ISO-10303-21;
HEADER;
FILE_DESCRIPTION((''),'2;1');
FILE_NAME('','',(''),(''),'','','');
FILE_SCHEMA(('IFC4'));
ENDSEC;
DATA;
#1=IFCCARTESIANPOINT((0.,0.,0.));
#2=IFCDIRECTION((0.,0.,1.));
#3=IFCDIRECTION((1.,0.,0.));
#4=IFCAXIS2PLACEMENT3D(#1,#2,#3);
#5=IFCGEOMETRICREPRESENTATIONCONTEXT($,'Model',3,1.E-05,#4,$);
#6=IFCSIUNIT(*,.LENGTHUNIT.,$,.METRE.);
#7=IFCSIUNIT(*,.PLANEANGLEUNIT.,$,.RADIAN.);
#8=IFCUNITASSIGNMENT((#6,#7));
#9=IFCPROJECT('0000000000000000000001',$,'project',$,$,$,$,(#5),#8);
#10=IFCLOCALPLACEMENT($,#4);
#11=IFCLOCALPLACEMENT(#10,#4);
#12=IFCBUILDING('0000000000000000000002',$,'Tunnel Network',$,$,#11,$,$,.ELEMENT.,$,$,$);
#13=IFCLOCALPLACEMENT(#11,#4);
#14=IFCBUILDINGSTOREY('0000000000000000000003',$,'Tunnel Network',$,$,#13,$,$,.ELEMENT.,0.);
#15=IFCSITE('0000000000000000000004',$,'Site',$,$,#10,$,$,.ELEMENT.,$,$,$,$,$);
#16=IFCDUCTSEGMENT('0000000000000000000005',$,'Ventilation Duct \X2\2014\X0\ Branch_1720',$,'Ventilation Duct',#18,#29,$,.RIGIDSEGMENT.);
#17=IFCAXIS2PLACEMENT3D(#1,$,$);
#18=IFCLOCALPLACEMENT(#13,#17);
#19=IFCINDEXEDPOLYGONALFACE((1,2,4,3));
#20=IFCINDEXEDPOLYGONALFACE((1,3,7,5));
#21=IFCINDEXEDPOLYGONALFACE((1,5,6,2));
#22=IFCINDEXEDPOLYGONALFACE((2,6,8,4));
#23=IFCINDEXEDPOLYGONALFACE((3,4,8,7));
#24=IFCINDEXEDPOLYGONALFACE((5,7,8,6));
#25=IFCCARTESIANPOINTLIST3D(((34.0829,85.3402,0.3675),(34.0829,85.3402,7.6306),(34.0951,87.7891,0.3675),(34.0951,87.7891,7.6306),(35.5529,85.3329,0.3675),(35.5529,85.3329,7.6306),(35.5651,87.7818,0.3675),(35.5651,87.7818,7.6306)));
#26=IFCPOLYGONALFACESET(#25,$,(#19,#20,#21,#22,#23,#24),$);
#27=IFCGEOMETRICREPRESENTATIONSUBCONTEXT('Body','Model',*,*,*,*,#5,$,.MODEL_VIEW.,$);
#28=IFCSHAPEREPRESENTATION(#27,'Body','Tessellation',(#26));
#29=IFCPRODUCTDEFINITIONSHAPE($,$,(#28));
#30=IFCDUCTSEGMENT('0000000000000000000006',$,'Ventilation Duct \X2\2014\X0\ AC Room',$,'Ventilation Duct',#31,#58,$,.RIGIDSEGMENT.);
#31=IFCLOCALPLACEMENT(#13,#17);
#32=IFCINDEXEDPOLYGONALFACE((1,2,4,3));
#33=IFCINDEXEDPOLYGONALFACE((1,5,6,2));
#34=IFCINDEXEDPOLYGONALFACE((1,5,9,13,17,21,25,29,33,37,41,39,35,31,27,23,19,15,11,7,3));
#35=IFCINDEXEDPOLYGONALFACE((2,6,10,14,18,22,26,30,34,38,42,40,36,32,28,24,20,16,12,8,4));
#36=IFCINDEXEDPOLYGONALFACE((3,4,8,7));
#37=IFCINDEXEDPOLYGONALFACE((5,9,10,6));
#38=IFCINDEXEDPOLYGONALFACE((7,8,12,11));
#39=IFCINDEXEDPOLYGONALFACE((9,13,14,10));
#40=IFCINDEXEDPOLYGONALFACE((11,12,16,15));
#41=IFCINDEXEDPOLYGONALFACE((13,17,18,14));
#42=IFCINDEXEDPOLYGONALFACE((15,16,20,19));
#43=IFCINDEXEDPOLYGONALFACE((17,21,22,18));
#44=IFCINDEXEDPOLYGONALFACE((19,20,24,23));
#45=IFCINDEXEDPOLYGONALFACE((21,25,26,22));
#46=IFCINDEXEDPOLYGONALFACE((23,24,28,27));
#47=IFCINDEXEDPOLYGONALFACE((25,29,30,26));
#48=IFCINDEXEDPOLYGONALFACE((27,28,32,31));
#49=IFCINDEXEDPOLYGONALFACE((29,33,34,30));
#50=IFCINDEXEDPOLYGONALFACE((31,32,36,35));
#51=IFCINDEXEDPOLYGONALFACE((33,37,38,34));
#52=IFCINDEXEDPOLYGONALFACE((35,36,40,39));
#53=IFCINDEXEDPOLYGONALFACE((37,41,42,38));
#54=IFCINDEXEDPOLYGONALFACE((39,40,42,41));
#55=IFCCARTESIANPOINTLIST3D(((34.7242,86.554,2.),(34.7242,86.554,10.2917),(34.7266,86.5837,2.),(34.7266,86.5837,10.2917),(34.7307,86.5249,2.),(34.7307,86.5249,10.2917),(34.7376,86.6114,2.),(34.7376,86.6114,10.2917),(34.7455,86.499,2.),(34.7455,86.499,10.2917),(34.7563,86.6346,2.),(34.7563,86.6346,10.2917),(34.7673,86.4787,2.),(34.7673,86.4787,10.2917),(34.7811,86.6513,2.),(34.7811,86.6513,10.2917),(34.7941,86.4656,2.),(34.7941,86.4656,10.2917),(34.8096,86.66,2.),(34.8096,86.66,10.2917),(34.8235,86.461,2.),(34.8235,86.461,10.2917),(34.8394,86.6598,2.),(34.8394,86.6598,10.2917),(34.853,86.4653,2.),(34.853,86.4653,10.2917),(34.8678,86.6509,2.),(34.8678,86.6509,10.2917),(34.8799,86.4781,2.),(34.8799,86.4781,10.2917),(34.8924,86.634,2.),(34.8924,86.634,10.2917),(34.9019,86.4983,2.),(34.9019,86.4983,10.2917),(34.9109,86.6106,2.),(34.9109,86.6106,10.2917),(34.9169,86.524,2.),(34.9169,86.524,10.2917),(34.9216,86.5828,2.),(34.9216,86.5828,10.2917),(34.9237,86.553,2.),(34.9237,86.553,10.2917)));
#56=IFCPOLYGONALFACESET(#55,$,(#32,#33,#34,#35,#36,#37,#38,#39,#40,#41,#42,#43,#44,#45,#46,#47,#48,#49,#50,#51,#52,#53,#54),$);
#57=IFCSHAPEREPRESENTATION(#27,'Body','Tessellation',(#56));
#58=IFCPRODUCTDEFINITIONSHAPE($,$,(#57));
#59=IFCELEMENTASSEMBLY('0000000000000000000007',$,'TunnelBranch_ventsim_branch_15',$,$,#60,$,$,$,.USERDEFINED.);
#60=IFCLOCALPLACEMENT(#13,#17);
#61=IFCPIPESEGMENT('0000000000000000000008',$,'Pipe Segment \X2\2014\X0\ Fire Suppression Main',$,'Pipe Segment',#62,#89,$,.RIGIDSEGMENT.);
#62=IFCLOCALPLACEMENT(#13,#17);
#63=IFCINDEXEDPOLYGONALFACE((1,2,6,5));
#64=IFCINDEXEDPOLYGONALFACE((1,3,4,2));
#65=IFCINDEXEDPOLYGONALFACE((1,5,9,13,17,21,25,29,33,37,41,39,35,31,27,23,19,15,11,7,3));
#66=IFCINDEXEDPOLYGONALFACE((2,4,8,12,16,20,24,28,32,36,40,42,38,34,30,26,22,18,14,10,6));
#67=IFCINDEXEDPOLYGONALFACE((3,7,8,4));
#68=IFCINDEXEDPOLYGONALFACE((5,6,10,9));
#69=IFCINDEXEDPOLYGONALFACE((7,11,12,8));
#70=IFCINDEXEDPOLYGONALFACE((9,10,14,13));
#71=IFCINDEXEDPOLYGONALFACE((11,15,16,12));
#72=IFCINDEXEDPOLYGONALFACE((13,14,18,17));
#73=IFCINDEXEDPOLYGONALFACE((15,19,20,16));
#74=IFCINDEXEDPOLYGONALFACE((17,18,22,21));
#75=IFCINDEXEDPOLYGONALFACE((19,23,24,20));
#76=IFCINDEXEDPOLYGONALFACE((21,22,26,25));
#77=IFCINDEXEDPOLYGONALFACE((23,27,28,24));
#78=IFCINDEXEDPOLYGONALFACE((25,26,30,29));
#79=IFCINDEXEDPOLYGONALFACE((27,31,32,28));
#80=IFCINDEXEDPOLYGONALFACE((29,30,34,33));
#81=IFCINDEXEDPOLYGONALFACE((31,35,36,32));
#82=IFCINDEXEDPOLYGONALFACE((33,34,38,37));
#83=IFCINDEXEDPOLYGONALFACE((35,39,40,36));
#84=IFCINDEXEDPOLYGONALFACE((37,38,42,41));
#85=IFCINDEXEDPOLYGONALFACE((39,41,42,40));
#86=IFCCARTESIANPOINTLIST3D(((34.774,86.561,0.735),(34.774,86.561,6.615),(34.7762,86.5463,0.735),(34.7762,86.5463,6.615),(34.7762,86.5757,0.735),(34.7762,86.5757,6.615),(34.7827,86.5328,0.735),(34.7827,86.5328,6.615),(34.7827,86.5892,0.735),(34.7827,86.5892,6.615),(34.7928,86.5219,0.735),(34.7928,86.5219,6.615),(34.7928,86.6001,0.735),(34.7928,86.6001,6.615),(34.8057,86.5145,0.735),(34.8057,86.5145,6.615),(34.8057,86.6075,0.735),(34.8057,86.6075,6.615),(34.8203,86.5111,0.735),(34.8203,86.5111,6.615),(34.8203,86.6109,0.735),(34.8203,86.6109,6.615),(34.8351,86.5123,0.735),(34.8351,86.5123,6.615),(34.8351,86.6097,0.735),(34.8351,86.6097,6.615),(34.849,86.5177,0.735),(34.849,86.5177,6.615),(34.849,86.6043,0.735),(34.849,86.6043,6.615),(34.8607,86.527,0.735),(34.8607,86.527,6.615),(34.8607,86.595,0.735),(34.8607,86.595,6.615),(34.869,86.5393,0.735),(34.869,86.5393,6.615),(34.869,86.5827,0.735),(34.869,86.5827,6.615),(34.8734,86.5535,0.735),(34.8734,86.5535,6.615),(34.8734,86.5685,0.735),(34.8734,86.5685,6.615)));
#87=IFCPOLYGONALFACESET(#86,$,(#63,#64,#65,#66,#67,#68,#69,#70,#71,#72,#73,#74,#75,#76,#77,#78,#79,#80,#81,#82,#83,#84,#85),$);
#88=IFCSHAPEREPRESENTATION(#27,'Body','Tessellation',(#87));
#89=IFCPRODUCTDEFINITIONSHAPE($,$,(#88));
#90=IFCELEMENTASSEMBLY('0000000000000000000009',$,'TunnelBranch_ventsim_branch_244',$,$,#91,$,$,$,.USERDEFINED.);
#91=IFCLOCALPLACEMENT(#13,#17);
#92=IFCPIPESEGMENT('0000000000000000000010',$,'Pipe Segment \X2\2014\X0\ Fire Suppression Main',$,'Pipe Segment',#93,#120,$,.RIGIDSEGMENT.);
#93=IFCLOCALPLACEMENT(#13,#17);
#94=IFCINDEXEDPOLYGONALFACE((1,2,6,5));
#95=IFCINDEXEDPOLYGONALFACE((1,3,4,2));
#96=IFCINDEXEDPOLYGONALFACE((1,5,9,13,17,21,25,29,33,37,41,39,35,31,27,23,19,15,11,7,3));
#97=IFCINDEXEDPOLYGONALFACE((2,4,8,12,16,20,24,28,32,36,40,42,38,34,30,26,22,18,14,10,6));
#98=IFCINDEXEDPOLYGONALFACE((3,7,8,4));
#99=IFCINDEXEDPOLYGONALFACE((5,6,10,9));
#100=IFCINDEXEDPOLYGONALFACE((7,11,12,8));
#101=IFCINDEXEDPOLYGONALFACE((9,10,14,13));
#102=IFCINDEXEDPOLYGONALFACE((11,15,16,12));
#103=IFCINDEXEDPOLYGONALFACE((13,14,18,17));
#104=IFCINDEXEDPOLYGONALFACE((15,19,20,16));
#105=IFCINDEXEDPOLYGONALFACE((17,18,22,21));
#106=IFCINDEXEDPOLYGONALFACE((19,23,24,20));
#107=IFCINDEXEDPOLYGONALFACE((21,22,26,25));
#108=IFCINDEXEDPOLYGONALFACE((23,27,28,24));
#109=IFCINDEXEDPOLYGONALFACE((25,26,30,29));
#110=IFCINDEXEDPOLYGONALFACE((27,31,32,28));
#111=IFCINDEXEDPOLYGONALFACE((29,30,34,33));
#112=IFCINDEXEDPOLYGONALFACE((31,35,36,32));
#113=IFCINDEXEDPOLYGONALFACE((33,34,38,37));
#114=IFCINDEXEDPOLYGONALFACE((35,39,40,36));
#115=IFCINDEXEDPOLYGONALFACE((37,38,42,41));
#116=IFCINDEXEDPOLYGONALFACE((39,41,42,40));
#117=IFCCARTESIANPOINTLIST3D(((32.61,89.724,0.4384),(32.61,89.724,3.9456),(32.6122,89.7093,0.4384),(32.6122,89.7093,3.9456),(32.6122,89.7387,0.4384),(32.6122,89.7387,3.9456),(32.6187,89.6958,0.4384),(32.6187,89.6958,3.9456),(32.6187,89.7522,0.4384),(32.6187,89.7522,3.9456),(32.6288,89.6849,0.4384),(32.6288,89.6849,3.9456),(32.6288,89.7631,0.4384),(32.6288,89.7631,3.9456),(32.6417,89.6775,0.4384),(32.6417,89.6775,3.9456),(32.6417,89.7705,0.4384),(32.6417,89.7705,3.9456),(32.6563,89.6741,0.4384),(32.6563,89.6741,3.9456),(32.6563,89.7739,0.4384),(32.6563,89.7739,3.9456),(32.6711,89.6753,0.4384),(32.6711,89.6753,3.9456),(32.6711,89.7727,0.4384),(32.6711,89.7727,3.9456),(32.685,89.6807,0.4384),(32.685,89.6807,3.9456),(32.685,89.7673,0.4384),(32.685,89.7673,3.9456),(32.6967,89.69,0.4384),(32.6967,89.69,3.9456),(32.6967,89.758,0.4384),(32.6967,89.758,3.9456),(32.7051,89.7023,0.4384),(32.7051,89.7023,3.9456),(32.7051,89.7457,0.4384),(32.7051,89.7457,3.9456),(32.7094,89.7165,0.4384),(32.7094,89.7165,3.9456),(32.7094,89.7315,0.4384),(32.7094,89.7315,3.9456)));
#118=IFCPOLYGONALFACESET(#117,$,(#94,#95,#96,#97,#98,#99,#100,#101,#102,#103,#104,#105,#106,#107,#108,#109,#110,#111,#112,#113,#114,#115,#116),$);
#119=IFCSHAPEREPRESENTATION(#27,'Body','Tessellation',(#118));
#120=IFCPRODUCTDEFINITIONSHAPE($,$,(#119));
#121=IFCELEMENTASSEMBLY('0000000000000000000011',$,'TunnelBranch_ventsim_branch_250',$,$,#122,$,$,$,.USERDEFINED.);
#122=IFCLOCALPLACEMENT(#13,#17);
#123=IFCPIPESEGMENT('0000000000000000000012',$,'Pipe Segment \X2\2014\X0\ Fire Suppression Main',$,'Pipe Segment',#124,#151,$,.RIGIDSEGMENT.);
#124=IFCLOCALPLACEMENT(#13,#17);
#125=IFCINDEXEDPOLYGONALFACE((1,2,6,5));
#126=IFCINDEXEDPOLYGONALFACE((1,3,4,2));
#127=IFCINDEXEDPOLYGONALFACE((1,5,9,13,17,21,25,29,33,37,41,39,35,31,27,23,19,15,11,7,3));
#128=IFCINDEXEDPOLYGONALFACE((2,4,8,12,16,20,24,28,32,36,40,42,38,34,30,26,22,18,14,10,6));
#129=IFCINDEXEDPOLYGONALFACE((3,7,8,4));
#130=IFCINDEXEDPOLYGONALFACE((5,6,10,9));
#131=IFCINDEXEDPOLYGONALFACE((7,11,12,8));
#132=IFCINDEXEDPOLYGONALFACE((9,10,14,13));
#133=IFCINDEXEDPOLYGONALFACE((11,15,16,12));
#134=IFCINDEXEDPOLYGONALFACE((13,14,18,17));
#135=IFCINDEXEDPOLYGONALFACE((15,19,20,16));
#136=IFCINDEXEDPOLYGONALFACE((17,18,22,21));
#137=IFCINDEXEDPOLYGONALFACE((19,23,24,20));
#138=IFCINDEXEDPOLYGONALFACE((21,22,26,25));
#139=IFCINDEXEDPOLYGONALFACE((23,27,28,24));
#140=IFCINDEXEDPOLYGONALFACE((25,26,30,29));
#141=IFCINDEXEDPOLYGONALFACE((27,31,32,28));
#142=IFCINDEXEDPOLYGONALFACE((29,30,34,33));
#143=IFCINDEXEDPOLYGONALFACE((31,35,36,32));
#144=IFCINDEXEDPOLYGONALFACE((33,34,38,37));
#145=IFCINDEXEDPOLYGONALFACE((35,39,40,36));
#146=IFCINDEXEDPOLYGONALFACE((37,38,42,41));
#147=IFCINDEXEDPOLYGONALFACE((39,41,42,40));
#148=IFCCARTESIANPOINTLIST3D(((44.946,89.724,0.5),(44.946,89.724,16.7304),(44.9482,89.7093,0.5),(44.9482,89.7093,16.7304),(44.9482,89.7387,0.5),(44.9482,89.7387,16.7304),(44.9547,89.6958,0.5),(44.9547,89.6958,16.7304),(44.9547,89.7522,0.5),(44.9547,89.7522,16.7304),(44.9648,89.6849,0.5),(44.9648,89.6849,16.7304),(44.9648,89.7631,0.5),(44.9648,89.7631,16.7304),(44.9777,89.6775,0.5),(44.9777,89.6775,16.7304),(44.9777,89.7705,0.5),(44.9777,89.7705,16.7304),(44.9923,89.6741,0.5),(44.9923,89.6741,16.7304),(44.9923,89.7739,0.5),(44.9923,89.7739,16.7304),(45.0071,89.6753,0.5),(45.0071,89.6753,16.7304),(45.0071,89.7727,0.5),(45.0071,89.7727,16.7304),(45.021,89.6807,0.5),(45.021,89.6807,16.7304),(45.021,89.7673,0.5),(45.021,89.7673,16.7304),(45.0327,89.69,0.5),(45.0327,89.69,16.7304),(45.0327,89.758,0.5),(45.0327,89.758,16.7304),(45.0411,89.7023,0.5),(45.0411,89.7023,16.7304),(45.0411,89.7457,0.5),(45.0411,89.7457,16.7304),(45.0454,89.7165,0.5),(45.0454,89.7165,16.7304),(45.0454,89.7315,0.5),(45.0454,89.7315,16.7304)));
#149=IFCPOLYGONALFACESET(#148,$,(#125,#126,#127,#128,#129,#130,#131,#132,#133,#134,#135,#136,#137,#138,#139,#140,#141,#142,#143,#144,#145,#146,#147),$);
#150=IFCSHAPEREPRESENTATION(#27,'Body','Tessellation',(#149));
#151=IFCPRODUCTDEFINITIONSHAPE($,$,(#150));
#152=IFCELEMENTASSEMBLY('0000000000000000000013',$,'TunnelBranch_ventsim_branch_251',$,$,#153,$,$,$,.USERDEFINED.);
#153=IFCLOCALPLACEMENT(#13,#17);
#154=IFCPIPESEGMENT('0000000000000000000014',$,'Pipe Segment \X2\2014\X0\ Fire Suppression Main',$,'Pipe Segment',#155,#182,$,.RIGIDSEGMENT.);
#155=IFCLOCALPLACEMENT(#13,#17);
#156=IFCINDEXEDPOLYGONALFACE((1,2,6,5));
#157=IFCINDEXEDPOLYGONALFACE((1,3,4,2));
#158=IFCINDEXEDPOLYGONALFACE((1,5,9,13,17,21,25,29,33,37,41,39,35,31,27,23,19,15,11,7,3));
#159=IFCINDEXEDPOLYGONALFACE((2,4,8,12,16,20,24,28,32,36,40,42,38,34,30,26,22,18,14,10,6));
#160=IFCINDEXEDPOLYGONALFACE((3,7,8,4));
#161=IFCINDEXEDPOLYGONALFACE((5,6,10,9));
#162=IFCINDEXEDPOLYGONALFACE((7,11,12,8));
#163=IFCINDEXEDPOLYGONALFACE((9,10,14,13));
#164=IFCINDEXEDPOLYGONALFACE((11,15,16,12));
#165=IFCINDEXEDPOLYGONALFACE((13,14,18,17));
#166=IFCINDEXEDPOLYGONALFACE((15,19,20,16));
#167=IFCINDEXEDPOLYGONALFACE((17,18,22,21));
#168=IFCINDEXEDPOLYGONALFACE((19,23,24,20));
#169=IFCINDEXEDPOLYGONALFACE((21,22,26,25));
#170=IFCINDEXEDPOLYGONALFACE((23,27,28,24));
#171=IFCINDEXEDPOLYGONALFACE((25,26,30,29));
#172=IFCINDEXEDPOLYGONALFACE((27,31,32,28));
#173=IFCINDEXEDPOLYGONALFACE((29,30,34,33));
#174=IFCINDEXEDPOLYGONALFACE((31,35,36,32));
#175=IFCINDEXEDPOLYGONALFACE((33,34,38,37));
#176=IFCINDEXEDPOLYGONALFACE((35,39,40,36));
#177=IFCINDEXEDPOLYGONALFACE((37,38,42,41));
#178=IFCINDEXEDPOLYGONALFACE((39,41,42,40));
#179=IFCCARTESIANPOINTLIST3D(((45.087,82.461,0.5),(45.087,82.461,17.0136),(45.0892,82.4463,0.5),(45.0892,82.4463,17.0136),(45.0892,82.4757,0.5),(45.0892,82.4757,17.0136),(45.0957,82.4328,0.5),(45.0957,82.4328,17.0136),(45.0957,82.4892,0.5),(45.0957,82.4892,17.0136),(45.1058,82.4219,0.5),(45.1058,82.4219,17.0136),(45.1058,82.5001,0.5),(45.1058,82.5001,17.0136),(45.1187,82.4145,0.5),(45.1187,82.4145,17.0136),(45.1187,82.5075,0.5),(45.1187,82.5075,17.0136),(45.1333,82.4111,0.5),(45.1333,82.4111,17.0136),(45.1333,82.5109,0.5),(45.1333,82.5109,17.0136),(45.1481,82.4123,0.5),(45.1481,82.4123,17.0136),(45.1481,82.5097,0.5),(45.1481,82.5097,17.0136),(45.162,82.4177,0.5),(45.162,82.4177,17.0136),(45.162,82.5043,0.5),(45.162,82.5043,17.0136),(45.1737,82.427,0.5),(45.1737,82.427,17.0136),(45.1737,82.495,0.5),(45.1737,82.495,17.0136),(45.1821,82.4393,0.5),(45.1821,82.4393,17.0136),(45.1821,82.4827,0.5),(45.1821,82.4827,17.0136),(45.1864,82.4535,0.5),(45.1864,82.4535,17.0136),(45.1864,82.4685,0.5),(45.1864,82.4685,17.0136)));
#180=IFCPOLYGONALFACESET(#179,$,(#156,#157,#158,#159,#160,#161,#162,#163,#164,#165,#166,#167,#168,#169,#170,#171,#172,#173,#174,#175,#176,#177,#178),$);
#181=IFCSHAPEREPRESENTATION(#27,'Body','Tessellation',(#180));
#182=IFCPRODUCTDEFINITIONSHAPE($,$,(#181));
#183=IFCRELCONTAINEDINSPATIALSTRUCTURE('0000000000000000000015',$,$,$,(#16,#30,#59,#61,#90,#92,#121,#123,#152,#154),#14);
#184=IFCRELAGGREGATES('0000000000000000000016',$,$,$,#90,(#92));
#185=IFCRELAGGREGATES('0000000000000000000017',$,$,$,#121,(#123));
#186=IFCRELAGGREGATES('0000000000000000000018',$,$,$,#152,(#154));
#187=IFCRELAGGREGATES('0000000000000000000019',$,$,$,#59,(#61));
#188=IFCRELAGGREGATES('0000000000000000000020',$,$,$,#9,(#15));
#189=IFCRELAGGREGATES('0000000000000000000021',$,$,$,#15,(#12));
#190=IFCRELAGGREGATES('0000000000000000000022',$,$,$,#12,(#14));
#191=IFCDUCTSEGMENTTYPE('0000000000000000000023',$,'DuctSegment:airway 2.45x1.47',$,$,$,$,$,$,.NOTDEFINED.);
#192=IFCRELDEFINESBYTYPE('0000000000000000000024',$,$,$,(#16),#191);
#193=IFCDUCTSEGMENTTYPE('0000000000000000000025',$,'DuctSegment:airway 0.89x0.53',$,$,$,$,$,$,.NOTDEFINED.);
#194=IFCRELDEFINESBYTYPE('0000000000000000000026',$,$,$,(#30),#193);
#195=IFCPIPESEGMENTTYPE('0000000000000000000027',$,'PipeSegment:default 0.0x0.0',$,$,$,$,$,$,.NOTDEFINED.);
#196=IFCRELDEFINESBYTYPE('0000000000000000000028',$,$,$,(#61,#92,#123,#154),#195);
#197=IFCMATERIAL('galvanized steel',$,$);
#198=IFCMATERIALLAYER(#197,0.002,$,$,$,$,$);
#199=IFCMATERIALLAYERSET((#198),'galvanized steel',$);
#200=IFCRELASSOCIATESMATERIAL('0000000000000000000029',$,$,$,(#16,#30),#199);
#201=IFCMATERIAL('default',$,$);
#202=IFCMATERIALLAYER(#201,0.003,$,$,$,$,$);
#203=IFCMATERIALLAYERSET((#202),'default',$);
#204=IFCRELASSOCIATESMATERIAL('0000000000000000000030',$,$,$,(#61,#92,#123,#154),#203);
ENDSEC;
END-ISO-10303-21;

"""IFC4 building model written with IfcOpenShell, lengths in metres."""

from ifc_helpers import new_model, entity, si_unit, frame, origin_with_axes, origin_2d_with_axis, place, context, subcontext, project, spatial, rectangle, circle, extrude, material, layer, layer_set, layer_usage, type_object, element, aggregate, save


model = new_model("IFC4")

# Units and contexts
model_context = context("Model", 3, precision=1e-05, world=origin_with_axes())
body_context = subcontext(model_context, "Body", "Model", "MODEL_VIEW")
ifc_project = project(units=[si_unit("LENGTHUNIT", "METRE"), si_unit("PLANEANGLEUNIT", "RADIAN")], contexts=[model_context])

# Site, building, storey
site_placement = place(None, origin_with_axes())
site = spatial("IfcSite", under=ifc_project, at=site_placement, Name="Site", CompositionType="ELEMENT")
building_placement = place(site_placement, origin_with_axes())
building = spatial("IfcBuilding", under=site, at=building_placement, Name="Tunnel Network", CompositionType="ELEMENT")
storey_placement = place(building_placement, origin_with_axes())
storey = spatial("IfcBuildingStorey", under=building, at=storey_placement, Name="Tunnel Network", CompositionType="ELEMENT", Elevation=0.0)

# Duct segments
ifc_material_1 = material(Name="galvanized steel")
ifc_layer_1 = layer(ifc_material_1, 0.002)
ifc_layer_set_1 = layer_set([ifc_layer_1], Name="galvanized steel")
ifc_layer_usage_1 = layer_usage(ifc_layer_set_1, "AXIS2", "POSITIVE", 0.0)
duct_segment_type_1 = type_object("IfcDuctSegmentType", Name="DuctSegment:airway 2.45x1.47")
duct_segment_1_placement = place(storey_placement, frame((34.824, 86.561, 0.3675), z_axis=(0.0, 0.0, 1.0), x_axis=(0.004956, 0.999988, 0.0)))
element("IfcDuctSegment", 1, at=duct_segment_1_placement, inside=storey, type_object=duct_segment_type_1, material=ifc_layer_usage_1, Name="Ventilation Duct — Branch_1720", ObjectType="Ventilation Duct", PredefinedType="RIGIDSEGMENT", context=body_context, shape_type="SweptSolid", body=[
    extrude(rectangle(XDim=2.449, YDim=1.47, at=origin_2d_with_axis()), origin_with_axes(), (0.0, 0.0, 1.0), 7.2631),
])
ifc_layer_usage_2 = layer_usage(ifc_layer_set_1, "AXIS2", "POSITIVE", 0.0)
duct_segment_type_2 = type_object("IfcDuctSegmentType", Name="DuctSegment:airway 0.89x0.53")
duct_segment_2_placement = place(storey_placement, frame((34.824, 86.561, 2.0), z_axis=(0.0, 0.0, 1.0), x_axis=(-0.004956, -0.999988, 0.0)))
element("IfcDuctSegment", 2, at=duct_segment_2_placement, inside=storey, type_object=duct_segment_type_2, material=ifc_layer_usage_2, Name="Ventilation Duct — AC Room", ObjectType="Ventilation Duct", PredefinedType="RIGIDSEGMENT", context=body_context, shape_type="AdvancedSweptSolid", body=[
    entity("IfcSweptDiskSolid", entity("IfcPolyline", [entity("IfcCartesianPoint", [0.0, 0.0, 0.0]), entity("IfcCartesianPoint", [0.0, 0.0, 8.2917])]), 0.1),
])

# Element assemblies, pipe segments
assembly_1_placement = place(storey_placement, frame((32.324, 84.436, 2.0), z_axis=(0.0, 1.0, 0.0), x_axis=(-1.0, 0.0, 0.0)))
assembly_1 = element("IfcElementAssembly", 3, at=assembly_1_placement, inside=storey, Name="TunnelBranch_ventsim_branch_15", PredefinedType="USERDEFINED")
ifc_material_2 = material(Name="default")
ifc_layer_2 = layer(ifc_material_2, 0.003)
ifc_layer_set_2 = layer_set([ifc_layer_2], Name="default")
ifc_layer_usage_3 = layer_usage(ifc_layer_set_2, "AXIS2", "POSITIVE", 0.0)
pipe_segment_type = type_object("IfcPipeSegmentType", Name="PipeSegment:default 0.0x0.0")
pipe_segment_1_placement = place(storey_placement, frame((34.824, 86.561, 0.735), z_axis=(0.0, 0.0, 1.0), x_axis=(-1.0, 0.0, 0.0)))
pipe_segment_1 = element("IfcPipeSegment", 4, at=pipe_segment_1_placement, inside=storey, type_object=pipe_segment_type, material=ifc_layer_usage_3, Name="Pipe Segment — Fire Suppression Main", ObjectType="Pipe Segment", PredefinedType="RIGIDSEGMENT", context=body_context, shape_type="SweptSolid", body=[
    extrude(circle(Radius=0.05, at=origin_2d_with_axis()), origin_with_axes(), (0.0, 0.0, 1.0), 5.88),
])
assembly_2_placement = place(storey_placement, frame((32.66, 89.724, 1.0), z_axis=(0.0, 1.0, 0.0), x_axis=(-1.0, 0.0, 0.0)))
assembly_2 = element("IfcElementAssembly", 5, at=assembly_2_placement, inside=storey, Name="TunnelBranch_ventsim_branch_244", PredefinedType="USERDEFINED")
ifc_layer_usage_4 = layer_usage(ifc_layer_set_2, "AXIS2", "POSITIVE", 0.0)
pipe_segment_2_placement = place(storey_placement, frame((32.66, 89.724, 0.4384), z_axis=(0.0, 0.0, 1.0), x_axis=(-1.0, 0.0, 0.0)))
pipe_segment_2 = element("IfcPipeSegment", 6, at=pipe_segment_2_placement, inside=storey, type_object=pipe_segment_type, material=ifc_layer_usage_4, Name="Pipe Segment — Fire Suppression Main", ObjectType="Pipe Segment", PredefinedType="RIGIDSEGMENT", context=body_context, shape_type="SweptSolid", body=[
    extrude(circle(Radius=0.05, at=origin_2d_with_axis()), origin_with_axes(), (0.0, 0.0, 1.0), 3.5072),
])
assembly_3_placement = place(storey_placement, frame((44.996, 89.724, 1.0), z_axis=(0.0, 1.0, 0.0), x_axis=(-1.0, 0.0, 0.0)))
assembly_3 = element("IfcElementAssembly", 7, at=assembly_3_placement, inside=storey, Name="TunnelBranch_ventsim_branch_250", PredefinedType="USERDEFINED")
ifc_layer_usage_5 = layer_usage(ifc_layer_set_2, "AXIS2", "POSITIVE", 0.0)
pipe_segment_3_placement = place(storey_placement, frame((44.996, 89.724, 0.5), z_axis=(0.0, 0.0, 1.0), x_axis=(-1.0, 0.0, 0.0)))
pipe_segment_3 = element("IfcPipeSegment", 8, at=pipe_segment_3_placement, inside=storey, type_object=pipe_segment_type, material=ifc_layer_usage_5, Name="Pipe Segment — Fire Suppression Main", ObjectType="Pipe Segment", PredefinedType="RIGIDSEGMENT", context=body_context, shape_type="SweptSolid", body=[
    extrude(circle(Radius=0.05, at=origin_2d_with_axis()), origin_with_axes(), (0.0, 0.0, 1.0), 16.2304),
])
assembly_4_placement = place(storey_placement, frame((45.137, 82.461, 1.0), z_axis=(0.0, 1.0, 0.0), x_axis=(-1.0, 0.0, 0.0)))
assembly_4 = element("IfcElementAssembly", 9, at=assembly_4_placement, inside=storey, Name="TunnelBranch_ventsim_branch_251", PredefinedType="USERDEFINED")
ifc_layer_usage_6 = layer_usage(ifc_layer_set_2, "AXIS2", "POSITIVE", 0.0)
pipe_segment_4_placement = place(storey_placement, frame((45.137, 82.461, 0.5), z_axis=(0.0, 0.0, 1.0), x_axis=(-1.0, 0.0, 0.0)))
pipe_segment_4 = element("IfcPipeSegment", 10, at=pipe_segment_4_placement, inside=storey, type_object=pipe_segment_type, material=ifc_layer_usage_6, Name="Pipe Segment — Fire Suppression Main", ObjectType="Pipe Segment", PredefinedType="RIGIDSEGMENT", context=body_context, shape_type="SweptSolid", body=[
    extrude(circle(Radius=0.05, at=origin_2d_with_axis()), origin_with_axes(), (0.0, 0.0, 1.0), 16.5136),
])

aggregate(assembly_2, [pipe_segment_2])
aggregate(assembly_3, [pipe_segment_3])
aggregate(assembly_4, [pipe_segment_4])

aggregate(assembly_1, [pipe_segment_1])

save(model, "model.ifc")
